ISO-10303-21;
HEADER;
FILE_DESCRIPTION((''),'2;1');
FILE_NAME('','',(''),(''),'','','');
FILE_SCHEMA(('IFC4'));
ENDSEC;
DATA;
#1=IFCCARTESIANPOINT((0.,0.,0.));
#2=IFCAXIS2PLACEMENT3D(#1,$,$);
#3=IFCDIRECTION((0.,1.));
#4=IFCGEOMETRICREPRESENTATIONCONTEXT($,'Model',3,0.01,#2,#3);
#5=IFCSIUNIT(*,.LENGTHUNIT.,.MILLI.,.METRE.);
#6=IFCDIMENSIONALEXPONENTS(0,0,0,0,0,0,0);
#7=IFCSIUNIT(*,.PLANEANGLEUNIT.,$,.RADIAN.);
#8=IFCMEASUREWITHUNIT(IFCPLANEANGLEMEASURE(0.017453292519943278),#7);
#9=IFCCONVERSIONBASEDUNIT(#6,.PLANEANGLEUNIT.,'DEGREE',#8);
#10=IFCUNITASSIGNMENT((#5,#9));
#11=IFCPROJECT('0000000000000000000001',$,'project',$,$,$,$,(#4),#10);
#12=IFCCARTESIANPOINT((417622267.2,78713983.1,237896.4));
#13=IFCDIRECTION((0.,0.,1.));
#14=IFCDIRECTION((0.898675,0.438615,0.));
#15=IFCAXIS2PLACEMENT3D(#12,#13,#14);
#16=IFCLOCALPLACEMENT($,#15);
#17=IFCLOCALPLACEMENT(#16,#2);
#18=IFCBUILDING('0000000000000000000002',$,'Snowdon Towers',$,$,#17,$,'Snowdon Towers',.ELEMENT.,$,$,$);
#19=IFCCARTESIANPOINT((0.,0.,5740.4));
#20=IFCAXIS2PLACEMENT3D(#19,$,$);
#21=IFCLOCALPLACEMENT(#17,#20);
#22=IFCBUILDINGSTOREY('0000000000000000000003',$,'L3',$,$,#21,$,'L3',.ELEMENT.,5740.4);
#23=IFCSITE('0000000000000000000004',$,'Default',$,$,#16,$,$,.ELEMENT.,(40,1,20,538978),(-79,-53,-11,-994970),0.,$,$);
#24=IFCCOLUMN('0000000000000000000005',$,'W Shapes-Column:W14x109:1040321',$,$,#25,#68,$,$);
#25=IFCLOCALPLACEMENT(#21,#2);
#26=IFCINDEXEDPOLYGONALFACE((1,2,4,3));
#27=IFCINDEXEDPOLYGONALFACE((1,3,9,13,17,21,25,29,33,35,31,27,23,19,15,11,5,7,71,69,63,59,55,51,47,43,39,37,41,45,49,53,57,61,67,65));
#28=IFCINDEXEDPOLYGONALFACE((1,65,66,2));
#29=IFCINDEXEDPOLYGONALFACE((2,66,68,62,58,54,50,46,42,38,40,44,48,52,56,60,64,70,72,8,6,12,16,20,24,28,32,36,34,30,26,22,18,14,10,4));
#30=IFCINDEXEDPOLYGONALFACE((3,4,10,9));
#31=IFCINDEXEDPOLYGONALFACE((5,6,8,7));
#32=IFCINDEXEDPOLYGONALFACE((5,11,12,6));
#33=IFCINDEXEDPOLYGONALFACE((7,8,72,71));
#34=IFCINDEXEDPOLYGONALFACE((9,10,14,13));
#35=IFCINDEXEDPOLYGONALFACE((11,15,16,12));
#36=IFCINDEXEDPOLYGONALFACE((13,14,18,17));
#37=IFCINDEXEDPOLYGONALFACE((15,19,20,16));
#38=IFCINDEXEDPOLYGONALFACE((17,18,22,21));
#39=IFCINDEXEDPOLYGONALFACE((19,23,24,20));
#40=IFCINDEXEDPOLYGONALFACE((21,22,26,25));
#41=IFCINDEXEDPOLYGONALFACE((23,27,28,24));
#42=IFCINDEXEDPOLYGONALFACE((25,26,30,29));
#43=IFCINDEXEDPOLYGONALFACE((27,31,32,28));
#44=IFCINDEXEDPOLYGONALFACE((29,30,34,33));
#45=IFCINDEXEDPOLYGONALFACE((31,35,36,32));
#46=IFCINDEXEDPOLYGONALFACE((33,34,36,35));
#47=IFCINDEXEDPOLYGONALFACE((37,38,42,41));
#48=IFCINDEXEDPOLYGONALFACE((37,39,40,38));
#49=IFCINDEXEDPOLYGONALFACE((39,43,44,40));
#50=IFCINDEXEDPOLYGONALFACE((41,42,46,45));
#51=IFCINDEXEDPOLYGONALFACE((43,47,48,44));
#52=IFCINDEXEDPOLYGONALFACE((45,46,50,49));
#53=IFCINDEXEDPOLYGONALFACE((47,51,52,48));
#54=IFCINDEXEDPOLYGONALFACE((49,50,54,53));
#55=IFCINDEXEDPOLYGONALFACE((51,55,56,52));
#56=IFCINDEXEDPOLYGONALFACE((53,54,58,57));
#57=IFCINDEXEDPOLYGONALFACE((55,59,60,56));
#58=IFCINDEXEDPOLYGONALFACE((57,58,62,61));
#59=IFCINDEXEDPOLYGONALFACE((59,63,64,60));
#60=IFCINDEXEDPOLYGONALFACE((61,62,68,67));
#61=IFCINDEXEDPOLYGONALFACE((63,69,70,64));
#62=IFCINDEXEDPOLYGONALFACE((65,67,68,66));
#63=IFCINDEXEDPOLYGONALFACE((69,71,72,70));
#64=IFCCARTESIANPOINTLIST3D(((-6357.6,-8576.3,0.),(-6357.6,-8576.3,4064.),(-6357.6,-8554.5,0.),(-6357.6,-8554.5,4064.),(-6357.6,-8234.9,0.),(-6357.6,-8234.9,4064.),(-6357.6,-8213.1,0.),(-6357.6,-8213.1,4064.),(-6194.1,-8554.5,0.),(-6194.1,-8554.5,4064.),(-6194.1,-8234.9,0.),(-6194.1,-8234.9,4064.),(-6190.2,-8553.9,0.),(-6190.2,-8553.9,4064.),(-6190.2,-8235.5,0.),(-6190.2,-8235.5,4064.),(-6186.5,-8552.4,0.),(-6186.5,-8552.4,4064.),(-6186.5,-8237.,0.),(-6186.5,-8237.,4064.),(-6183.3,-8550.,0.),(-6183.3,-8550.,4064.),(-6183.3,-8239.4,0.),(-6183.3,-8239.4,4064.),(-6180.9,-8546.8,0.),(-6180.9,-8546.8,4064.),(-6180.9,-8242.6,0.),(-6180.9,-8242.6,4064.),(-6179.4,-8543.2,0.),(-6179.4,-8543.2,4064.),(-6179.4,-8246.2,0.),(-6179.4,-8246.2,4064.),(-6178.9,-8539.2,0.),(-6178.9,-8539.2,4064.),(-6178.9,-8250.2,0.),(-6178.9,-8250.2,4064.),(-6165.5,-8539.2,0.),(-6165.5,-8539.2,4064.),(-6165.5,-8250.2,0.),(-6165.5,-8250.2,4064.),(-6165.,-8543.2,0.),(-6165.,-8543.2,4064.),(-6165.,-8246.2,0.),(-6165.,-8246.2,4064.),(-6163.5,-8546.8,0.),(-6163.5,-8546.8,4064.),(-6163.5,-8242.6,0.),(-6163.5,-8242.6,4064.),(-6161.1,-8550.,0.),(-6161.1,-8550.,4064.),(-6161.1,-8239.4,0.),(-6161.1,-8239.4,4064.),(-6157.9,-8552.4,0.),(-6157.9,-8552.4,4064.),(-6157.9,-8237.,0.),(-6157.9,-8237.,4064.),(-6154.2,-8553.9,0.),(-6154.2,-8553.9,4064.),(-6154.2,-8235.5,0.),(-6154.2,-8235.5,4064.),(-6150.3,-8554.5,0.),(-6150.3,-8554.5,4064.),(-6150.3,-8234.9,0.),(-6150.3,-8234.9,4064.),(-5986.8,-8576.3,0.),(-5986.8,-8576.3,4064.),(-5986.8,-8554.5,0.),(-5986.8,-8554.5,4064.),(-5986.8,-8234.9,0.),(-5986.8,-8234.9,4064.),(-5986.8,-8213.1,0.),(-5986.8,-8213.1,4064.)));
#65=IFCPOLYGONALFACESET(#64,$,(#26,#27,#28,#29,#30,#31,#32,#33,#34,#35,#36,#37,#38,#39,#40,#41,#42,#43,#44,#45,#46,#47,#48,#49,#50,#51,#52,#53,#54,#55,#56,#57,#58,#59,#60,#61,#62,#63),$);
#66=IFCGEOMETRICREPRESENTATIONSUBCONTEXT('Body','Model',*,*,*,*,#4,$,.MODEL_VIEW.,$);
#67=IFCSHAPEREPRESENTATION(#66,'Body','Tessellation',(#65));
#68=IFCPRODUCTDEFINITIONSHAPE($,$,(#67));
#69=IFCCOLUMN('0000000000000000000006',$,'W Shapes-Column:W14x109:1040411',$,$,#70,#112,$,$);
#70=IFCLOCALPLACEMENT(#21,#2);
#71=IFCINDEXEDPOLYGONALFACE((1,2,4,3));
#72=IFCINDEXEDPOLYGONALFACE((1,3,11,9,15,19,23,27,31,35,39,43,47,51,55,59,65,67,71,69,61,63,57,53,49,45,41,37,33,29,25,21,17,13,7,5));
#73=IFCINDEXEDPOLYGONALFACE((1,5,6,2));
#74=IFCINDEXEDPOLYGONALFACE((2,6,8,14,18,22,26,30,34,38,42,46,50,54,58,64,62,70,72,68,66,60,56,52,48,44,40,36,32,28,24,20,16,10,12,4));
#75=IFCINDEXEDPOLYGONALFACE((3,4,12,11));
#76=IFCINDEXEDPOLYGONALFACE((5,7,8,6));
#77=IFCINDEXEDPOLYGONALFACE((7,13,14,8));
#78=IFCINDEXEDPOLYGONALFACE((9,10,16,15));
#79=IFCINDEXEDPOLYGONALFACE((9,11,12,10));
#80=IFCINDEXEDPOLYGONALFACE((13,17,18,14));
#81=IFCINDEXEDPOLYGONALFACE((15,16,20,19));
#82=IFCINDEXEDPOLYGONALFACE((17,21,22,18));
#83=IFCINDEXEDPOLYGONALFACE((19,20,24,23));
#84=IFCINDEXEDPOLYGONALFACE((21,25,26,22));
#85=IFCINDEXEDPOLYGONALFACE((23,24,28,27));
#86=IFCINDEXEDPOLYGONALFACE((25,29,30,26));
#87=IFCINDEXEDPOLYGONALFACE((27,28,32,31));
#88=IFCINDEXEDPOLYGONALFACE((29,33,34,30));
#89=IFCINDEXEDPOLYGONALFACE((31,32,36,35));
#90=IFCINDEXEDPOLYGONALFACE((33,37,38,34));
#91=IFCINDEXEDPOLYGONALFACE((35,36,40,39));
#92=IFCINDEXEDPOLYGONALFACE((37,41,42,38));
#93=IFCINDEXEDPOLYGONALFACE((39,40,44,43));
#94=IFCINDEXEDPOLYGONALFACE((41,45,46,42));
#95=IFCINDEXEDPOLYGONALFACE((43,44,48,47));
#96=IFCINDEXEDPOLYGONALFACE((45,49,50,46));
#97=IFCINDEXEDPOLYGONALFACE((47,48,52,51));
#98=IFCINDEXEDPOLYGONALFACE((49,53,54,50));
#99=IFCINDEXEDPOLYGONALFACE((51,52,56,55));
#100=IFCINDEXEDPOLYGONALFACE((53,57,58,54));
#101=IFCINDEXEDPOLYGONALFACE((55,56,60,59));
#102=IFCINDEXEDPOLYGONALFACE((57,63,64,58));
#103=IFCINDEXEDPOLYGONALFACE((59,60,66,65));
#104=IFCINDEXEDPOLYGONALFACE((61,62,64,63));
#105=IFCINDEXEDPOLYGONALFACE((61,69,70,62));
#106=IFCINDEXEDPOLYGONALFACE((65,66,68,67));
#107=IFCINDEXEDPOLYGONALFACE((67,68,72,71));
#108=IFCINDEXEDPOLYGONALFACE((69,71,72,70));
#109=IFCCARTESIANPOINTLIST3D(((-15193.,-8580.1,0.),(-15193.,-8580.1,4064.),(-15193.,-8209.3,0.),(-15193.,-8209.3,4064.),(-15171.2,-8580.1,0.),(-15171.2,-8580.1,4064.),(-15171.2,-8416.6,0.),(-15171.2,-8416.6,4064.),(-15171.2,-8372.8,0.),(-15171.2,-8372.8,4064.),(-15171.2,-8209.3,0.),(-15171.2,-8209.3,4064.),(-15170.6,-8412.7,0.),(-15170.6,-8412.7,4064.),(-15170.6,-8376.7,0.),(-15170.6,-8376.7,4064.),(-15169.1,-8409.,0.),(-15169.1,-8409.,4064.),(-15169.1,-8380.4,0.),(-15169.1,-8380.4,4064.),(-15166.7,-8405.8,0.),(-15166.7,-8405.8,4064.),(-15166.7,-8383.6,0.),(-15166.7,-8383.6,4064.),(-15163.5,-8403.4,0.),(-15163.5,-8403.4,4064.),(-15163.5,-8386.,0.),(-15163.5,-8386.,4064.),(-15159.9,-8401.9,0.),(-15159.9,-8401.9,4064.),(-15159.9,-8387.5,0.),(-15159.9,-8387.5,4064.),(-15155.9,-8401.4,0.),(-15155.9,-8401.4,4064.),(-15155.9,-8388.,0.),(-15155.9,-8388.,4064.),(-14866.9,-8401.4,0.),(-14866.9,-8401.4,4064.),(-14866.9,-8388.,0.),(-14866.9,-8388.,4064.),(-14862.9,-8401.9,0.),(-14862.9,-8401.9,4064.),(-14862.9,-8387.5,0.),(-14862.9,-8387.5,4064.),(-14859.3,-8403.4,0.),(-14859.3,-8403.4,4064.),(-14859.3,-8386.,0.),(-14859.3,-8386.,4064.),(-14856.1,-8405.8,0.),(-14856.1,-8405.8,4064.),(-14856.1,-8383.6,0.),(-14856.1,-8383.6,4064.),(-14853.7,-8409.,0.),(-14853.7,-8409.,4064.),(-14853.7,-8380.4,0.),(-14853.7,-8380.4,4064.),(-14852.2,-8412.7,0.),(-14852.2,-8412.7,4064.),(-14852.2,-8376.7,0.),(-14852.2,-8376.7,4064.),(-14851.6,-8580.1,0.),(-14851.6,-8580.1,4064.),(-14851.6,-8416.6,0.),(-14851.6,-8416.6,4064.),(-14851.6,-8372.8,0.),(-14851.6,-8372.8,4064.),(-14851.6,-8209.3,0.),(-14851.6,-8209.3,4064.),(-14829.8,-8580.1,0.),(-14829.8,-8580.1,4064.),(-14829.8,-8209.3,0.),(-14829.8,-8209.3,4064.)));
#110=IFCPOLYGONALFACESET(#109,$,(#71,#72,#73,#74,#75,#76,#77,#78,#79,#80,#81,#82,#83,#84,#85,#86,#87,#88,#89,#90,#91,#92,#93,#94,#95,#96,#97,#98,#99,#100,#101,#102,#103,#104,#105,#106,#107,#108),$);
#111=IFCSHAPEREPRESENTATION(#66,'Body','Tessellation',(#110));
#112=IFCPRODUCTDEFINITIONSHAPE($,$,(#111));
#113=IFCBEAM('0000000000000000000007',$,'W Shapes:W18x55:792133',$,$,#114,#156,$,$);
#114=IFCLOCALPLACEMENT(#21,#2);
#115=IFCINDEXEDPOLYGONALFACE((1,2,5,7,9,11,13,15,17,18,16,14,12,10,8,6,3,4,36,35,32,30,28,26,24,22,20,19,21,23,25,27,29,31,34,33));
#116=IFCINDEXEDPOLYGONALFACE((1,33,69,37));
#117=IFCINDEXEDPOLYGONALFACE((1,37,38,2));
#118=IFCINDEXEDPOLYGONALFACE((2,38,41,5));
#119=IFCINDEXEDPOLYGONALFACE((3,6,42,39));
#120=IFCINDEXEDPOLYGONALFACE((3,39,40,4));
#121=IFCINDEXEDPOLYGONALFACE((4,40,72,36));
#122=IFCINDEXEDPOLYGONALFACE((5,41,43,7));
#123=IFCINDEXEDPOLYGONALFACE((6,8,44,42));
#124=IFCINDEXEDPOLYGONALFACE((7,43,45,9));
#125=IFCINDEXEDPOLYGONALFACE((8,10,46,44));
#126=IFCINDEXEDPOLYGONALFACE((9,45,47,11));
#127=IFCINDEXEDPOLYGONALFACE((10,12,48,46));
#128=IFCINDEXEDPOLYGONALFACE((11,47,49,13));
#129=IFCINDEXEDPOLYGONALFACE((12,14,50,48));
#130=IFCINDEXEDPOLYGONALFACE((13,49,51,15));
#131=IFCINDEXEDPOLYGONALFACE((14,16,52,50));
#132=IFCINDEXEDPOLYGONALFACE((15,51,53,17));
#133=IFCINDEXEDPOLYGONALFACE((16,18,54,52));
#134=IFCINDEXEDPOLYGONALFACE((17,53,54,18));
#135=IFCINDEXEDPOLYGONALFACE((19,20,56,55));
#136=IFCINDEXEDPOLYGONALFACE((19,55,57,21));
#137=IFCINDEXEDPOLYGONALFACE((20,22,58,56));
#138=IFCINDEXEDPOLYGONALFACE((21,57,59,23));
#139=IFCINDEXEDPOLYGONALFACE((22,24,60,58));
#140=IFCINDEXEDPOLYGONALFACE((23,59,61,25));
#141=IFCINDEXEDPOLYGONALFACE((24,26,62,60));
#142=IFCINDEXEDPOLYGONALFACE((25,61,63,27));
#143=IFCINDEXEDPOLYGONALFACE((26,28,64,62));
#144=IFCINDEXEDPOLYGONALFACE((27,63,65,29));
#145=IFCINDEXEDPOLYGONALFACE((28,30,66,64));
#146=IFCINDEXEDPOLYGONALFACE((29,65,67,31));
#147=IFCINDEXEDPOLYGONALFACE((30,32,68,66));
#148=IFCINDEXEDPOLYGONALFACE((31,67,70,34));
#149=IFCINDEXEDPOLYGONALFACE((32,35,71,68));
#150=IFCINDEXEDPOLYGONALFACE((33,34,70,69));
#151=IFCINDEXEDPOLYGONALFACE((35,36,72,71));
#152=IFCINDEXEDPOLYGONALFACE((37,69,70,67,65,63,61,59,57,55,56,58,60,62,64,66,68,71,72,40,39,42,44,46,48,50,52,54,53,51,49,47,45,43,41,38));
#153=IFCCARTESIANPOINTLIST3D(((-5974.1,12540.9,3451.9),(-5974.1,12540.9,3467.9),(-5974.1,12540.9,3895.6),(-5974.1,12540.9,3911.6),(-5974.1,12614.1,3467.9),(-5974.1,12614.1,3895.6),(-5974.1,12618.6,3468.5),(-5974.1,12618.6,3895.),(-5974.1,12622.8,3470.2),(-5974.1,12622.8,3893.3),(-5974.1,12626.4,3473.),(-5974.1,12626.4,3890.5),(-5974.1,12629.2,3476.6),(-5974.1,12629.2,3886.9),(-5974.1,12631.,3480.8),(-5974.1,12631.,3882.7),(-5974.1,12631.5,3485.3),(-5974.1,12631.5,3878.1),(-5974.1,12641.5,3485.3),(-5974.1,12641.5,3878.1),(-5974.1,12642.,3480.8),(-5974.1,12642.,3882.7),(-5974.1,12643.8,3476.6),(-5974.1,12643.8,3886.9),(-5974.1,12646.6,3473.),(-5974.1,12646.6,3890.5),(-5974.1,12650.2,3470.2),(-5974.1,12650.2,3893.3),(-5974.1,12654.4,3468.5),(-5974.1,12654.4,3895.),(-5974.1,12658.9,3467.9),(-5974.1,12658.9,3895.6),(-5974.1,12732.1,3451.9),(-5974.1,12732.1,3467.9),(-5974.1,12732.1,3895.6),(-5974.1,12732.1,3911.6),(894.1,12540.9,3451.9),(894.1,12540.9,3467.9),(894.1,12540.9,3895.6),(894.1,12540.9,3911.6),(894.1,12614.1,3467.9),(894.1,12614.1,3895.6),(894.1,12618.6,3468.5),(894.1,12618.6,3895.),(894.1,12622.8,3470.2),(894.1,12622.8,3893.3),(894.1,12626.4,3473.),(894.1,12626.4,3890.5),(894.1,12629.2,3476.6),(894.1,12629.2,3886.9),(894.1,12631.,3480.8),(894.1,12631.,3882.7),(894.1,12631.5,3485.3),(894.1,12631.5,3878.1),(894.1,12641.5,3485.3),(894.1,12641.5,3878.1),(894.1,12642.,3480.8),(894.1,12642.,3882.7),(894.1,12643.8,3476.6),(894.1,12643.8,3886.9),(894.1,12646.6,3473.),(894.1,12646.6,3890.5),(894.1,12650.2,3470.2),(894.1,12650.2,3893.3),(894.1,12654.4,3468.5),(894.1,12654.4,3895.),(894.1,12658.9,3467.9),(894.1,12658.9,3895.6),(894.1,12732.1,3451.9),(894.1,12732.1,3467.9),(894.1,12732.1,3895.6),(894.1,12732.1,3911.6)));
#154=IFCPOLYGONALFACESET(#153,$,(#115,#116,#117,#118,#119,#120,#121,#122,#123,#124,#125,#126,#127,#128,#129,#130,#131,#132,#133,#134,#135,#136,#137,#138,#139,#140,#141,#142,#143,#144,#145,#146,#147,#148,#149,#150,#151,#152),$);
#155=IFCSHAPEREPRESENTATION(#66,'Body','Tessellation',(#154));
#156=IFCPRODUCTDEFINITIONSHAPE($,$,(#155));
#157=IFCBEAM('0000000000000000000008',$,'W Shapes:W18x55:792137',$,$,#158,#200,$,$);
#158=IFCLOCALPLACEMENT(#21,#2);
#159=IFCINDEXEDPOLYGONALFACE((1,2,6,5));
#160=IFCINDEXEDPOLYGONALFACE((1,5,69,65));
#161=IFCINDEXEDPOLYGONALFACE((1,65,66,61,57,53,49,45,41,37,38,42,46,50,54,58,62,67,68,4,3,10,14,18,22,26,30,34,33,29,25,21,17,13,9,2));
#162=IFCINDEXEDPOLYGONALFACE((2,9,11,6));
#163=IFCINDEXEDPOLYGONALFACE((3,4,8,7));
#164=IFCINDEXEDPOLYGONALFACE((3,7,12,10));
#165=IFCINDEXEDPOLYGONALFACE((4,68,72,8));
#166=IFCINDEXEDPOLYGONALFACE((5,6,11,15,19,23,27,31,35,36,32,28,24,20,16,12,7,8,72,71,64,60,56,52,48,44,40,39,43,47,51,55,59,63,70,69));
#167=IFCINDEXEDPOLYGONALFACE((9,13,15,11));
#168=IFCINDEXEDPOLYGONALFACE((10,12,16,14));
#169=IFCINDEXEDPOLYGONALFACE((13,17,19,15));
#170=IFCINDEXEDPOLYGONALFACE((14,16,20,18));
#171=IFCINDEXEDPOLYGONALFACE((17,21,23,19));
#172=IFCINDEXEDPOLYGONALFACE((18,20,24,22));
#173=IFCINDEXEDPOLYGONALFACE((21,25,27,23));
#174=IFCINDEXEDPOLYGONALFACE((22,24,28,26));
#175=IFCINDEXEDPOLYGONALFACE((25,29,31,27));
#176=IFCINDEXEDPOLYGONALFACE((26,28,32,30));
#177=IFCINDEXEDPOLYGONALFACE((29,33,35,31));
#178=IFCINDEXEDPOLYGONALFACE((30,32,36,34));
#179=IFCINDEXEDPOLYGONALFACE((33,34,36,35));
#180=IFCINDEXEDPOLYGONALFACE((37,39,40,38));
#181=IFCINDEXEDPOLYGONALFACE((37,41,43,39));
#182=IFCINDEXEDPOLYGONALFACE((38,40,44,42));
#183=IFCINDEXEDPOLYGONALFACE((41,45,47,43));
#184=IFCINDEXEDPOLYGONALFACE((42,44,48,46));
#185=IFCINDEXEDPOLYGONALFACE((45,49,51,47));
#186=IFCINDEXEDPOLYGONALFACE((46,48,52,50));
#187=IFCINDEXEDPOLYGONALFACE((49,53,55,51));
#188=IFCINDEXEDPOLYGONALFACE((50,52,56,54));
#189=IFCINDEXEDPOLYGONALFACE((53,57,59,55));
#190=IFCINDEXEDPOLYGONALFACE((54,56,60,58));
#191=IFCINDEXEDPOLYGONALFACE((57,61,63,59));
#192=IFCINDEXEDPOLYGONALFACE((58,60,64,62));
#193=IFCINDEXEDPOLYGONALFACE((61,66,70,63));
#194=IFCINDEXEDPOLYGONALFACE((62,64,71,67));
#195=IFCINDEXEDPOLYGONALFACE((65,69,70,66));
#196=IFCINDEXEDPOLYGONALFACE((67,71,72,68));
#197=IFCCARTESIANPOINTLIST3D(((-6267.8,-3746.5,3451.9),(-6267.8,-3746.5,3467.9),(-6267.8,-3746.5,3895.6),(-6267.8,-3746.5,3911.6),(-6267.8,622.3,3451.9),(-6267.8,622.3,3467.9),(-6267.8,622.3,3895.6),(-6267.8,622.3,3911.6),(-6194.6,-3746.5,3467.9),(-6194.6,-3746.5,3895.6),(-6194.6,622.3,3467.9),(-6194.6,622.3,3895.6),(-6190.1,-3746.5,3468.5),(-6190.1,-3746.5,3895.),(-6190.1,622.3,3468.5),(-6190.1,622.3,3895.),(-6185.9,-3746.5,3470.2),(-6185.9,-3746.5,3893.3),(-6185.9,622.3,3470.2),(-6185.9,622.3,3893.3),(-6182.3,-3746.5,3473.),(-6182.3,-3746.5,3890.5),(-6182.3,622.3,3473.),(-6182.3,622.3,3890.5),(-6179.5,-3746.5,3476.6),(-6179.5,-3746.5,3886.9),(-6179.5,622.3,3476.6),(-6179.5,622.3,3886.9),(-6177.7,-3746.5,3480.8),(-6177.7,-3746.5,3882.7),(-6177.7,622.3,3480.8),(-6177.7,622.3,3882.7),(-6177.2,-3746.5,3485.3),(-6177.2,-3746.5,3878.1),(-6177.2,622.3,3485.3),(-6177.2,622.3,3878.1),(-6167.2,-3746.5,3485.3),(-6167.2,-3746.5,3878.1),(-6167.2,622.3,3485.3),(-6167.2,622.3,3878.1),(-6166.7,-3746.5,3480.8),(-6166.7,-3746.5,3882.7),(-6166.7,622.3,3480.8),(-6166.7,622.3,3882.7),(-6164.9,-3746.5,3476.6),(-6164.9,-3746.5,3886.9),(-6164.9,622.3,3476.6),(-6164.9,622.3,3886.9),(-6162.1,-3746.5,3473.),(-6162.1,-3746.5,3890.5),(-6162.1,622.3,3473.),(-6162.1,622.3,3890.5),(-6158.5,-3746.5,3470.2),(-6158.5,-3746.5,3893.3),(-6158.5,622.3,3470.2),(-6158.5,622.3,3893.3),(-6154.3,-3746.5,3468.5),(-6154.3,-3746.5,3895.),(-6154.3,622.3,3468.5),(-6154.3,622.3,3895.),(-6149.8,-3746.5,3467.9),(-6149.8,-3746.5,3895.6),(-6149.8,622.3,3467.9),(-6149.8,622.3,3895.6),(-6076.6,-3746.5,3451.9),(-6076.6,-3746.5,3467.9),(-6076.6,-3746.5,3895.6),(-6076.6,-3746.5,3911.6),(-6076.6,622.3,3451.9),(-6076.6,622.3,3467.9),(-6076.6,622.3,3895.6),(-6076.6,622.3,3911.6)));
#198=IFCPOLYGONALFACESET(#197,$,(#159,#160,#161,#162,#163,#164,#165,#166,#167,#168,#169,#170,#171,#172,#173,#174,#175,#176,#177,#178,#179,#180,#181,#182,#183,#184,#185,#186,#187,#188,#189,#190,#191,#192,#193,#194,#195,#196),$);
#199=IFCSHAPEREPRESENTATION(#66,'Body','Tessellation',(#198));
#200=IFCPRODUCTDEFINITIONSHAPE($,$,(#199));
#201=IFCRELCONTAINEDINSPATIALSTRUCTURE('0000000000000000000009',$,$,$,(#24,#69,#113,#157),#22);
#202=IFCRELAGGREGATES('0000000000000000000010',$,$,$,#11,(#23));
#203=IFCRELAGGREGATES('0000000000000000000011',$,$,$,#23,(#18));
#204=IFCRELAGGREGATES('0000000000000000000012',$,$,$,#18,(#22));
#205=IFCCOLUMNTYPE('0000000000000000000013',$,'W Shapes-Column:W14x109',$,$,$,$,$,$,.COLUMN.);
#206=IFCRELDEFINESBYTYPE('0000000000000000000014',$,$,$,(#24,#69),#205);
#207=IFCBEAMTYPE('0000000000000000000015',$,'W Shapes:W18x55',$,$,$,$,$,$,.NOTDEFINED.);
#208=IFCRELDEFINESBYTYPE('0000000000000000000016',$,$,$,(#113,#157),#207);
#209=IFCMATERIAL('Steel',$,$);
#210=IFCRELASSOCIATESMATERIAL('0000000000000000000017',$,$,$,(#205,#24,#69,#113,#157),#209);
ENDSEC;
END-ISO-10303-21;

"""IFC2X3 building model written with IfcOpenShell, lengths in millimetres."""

from ifc_helpers import new_model, entity, si_unit, converted_unit, direction, frame, frame_2d, origin, place, context, subcontext, project, spatial, i_section, extrude, source, transform, mapped, material, type_object, type_shapes, element, save


model = new_model("IFC2X3")

# Units and contexts
model_context = context("Model", 3, precision=0.01, world=origin(), true_north=direction((0.0, 1.0)))
body_context = subcontext(model_context, "Body", "Model", "MODEL_VIEW")
ifc_project = project(units=[si_unit("LENGTHUNIT", "METRE", prefix="MILLI"), converted_unit("PLANEANGLEUNIT", "DEGREE", entity("IfcPlaneAngleMeasure", 0.017453292519943278), si_unit("PLANEANGLEUNIT", "RADIAN"), dimensions=[0, 0, 0, 0, 0, 0, 0])], contexts=[model_context])

# Site, building, storey
site_placement = place(None, frame((417622267.2, 78713983.1, 237896.4), z_axis=(0.0, 0.0, 1.0), x_axis=(0.898675, 0.438615, 0.0)))
site = spatial("IfcSite", under=ifc_project, at=site_placement, Name="Default", CompositionType="ELEMENT", RefLatitude=(40, 1, 20, 538978), RefLongitude=(-79, -53, -11, -994970), RefElevation=0.0)
building_placement = place(site_placement, origin())
building = spatial("IfcBuilding", under=site, at=building_placement, Name="Snowdon Towers", LongName="Snowdon Towers", CompositionType="ELEMENT")
storey_placement = place(building_placement, frame((0.0, 0.0, 5740.4)))
storey = spatial("IfcBuildingStorey", under=building, at=storey_placement, Name="L3", LongName="L3", CompositionType="ELEMENT", Elevation=5740.4)

# Columns
ifc_material_1 = material(Name="Steel")
column_type_1 = type_object("IfcColumnType", Name="W Shapes-Column:W14x109", PredefinedType="COLUMN", material=ifc_material_1)
shared_shape_1 = source(origin(), body_context, "Body", "SweptSolid", [
    extrude(i_section(OverallWidth=370.8, OverallDepth=363.2, WebThickness=13.3, FlangeThickness=21.8, FilletRadius=15.2, at=frame_2d((0.0, 0.0), x_axis=(1.0, 0.0))), frame((0.0, 0.0, 5740.4), z_axis=(0.0, 0.0, 1.0), x_axis=(-1.0, 0.0, 0.0)), (0.0, 0.0, 1.0), 4064.0),
])
type_shapes(column_type_1, [shared_shape_1])
for number, where, z_axis, x_axis, name in (
    (1, (-6172.2, -8394.7, -5740.4), (0.0, 0.0, 1.0), (-1.0, 0.0, 0.0), "W Shapes-Column:W14x109:1040321"),
    (2, (-15011.4, -8394.7, -5740.4), (0.0, 0.0, 1.0), (0.0, 1.0, 0.0), "W Shapes-Column:W14x109:1040411"),
):
    element("IfcColumn", number, at=place(storey_placement, frame(where, z_axis=z_axis, x_axis=x_axis)), inside=storey, type_object=column_type_1, material=ifc_material_1, Name=name, context=body_context, shape_type="MappedRepresentation", body=[
        mapped(shared_shape_1, transform((0.0, 0.0, 0.0), scale=1.0)),
    ])

# Beams
beam_type = type_object("IfcBeamType", Name="W Shapes:W18x55", PredefinedType="NOTDEFINED")
beam_1_placement = place(storey_placement, frame((-6172.2, 12636.5, 3911.6)))
element("IfcBeam", 3, at=beam_1_placement, inside=storey, type_object=beam_type, material=ifc_material_1, Name="W Shapes:W18x55:792133", context=body_context, shape_type="SweptSolid", body=[
    extrude(i_section(OverallWidth=191.3, OverallDepth=459.7, WebThickness=9.9, FlangeThickness=16.0, FilletRadius=17.5, at=frame_2d((0.0, 0.0), x_axis=(0.0, 1.0))), frame((198.1, 0.0, -229.9), z_axis=(1.0, 0.0, 0.0), x_axis=(0.0, 0.0, -1.0)), (0.0, 0.0, 1.0), 6868.2),
])
beam_2_placement = place(storey_placement, frame((-6172.2, 762.0, 3911.6), z_axis=(0.0, 0.0, 1.0), x_axis=(0.0, -1.0, 0.0)))
element("IfcBeam", 4, at=beam_2_placement, inside=storey, type_object=beam_type, material=ifc_material_1, Name="W Shapes:W18x55:792137", context=body_context, shape_type="SweptSolid", body=[
    extrude(i_section(OverallWidth=191.3, OverallDepth=459.7, WebThickness=9.9, FlangeThickness=16.0, FilletRadius=17.5, at=frame_2d((0.0, 0.0), x_axis=(0.0, 1.0))), frame((139.7, 0.0, -229.9), z_axis=(1.0, 0.0, 0.0), x_axis=(0.0, 0.0, -1.0)), (0.0, 0.0, 1.0), 4368.8),
])

save(model, "model.ifc")
